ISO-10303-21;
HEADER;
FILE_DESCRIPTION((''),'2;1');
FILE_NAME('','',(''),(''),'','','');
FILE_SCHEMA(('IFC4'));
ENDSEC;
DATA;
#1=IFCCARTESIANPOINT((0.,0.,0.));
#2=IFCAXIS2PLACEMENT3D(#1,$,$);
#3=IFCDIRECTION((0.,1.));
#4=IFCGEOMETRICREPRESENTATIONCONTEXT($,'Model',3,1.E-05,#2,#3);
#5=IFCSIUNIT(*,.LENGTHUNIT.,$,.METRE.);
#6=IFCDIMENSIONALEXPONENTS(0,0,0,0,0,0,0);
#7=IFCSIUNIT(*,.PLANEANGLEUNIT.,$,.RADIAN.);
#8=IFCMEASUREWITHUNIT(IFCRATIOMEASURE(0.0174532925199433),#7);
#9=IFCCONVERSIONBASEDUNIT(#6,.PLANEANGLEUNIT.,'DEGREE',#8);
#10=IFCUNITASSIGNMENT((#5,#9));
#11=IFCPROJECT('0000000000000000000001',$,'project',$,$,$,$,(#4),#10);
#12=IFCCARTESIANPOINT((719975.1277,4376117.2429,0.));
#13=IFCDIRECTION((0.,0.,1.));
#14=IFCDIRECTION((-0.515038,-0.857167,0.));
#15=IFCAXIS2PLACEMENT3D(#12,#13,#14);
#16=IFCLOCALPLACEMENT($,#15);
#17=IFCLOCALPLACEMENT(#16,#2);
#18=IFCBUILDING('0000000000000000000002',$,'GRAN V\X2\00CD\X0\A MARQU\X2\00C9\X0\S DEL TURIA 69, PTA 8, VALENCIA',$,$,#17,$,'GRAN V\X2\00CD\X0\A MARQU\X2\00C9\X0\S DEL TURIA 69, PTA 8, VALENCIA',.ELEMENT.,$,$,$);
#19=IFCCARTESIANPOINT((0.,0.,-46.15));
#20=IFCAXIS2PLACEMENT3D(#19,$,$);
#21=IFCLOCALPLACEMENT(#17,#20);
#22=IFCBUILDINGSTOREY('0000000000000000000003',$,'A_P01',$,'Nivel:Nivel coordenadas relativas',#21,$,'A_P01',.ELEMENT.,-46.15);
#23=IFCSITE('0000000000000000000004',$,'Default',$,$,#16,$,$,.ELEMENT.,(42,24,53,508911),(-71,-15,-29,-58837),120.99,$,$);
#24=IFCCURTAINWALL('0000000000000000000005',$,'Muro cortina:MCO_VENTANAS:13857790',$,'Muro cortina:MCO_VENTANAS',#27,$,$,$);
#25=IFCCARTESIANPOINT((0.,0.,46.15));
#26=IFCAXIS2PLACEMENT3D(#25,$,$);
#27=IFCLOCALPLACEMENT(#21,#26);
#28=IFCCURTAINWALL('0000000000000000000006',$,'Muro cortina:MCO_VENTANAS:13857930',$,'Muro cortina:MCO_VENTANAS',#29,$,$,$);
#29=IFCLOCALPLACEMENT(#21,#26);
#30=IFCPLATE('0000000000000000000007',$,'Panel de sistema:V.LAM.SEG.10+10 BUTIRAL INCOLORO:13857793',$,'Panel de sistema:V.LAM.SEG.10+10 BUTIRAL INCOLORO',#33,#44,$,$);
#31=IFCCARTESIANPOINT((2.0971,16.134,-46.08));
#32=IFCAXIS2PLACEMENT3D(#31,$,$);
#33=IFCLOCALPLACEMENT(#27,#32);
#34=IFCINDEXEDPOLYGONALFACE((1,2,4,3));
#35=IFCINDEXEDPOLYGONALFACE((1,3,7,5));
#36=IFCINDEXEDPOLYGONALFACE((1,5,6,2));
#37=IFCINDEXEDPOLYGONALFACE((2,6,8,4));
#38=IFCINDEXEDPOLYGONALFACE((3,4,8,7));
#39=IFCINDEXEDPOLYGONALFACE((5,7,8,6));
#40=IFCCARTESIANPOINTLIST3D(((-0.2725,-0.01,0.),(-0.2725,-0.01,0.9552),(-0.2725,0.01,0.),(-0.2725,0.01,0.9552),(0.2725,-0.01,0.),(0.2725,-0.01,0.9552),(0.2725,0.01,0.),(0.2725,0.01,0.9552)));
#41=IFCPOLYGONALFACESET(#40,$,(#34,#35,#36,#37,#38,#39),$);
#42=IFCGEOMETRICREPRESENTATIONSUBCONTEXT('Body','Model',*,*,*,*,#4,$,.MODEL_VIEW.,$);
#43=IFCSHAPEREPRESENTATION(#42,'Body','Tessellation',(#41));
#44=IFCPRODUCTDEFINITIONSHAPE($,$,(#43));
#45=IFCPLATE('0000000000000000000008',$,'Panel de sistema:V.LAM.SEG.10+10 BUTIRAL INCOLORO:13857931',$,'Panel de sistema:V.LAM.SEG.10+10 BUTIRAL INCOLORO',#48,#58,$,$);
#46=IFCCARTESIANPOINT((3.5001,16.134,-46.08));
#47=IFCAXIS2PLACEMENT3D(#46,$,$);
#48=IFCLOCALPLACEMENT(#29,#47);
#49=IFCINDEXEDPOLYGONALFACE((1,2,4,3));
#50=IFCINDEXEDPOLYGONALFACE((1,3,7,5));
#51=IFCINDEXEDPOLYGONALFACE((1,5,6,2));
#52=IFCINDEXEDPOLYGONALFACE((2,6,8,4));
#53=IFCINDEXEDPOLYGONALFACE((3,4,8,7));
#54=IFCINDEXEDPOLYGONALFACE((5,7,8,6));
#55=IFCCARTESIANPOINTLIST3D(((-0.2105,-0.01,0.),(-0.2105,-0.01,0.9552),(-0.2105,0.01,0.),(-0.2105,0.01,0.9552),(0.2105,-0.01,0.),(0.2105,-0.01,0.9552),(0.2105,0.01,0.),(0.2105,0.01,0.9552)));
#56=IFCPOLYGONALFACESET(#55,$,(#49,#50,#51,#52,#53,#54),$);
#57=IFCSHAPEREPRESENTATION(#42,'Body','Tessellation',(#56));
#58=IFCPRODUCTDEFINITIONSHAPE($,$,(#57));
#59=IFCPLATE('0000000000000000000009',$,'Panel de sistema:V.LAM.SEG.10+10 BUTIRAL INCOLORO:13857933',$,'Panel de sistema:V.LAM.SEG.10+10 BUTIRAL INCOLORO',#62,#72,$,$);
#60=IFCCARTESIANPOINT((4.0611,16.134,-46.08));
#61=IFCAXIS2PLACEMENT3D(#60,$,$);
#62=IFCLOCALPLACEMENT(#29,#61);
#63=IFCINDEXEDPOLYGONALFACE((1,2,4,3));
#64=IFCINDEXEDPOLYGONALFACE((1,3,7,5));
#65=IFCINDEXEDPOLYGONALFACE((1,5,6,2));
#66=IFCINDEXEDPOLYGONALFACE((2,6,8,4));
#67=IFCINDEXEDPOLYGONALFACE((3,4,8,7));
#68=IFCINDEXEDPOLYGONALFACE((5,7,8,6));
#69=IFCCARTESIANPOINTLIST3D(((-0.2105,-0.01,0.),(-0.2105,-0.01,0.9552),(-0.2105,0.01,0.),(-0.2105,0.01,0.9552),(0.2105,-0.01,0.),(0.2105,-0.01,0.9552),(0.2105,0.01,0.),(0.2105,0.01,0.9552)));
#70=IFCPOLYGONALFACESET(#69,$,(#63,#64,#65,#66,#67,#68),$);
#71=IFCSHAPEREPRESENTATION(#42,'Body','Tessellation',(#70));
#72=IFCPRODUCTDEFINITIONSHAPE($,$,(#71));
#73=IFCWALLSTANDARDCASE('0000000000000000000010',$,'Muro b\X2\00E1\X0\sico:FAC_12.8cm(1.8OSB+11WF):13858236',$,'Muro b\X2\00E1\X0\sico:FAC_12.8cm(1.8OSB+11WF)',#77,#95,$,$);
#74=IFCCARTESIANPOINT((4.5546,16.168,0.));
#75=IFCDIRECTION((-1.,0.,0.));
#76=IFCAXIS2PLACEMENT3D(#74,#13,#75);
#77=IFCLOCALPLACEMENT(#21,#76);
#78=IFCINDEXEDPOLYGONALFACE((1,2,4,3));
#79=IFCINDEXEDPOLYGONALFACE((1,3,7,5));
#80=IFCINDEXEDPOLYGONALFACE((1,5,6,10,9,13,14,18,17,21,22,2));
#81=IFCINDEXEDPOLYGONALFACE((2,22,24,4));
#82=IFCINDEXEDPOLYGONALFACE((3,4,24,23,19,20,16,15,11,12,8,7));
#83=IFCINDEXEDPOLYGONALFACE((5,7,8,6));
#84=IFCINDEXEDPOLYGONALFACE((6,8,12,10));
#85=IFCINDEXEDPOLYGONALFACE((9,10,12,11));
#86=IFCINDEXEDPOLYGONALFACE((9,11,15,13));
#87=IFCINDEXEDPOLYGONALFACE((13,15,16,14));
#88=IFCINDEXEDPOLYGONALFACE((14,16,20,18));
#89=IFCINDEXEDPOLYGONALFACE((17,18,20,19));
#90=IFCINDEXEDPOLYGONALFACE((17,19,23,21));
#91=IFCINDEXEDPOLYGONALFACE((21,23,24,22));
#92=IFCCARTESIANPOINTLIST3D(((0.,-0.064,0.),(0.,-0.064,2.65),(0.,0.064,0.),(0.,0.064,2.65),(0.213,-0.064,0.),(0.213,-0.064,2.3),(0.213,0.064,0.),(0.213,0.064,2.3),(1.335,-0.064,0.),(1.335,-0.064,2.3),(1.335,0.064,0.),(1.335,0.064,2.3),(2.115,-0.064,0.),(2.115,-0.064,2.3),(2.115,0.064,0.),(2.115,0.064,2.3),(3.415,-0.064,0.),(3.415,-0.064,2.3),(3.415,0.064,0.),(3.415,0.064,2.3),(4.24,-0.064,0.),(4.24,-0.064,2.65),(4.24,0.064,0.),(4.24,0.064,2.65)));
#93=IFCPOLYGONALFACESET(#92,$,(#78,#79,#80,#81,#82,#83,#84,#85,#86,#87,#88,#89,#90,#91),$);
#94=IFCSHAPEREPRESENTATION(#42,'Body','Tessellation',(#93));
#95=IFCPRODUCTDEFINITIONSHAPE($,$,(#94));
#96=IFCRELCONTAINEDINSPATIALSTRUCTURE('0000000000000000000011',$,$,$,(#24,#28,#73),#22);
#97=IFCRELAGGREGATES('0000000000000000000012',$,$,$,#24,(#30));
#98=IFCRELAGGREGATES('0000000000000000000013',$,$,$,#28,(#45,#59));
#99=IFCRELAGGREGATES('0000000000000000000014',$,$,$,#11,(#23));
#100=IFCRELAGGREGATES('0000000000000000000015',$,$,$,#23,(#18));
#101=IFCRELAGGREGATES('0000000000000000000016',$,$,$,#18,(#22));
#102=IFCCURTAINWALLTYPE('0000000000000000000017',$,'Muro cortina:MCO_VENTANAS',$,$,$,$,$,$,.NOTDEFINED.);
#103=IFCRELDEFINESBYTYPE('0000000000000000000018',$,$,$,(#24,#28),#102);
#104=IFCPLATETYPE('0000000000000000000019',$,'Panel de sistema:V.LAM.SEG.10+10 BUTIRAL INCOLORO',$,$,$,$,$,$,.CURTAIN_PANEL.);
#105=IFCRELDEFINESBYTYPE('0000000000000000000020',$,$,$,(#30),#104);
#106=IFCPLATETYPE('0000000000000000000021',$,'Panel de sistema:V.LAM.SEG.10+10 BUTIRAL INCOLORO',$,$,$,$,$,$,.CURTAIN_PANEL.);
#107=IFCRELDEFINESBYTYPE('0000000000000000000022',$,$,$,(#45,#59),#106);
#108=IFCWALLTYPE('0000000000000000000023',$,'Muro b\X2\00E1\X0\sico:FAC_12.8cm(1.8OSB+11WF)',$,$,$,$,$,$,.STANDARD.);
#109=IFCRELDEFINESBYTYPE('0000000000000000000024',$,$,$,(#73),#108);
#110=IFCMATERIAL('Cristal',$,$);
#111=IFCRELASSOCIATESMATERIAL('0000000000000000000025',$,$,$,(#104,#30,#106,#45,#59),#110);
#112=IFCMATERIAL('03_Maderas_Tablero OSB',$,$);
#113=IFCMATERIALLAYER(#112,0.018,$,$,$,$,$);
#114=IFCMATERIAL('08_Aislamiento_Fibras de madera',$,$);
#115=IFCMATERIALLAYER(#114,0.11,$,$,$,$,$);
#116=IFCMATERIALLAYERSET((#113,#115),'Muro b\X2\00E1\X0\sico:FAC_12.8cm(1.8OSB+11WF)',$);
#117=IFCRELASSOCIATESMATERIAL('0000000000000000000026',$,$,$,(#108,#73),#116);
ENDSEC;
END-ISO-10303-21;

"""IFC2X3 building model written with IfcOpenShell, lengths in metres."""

from ifc_helpers import new_model, entity, si_unit, converted_unit, direction, frame, frame_2d, origin, origin_2d_with_axis, place, context, subcontext, project, spatial, rectangle, extrude, source, transform, mapped, material, layer, layer_set, layer_usage, type_object, type_shapes, element, aggregate, save


model = new_model("IFC2X3")

# Units and contexts
model_context = context("Model", 3, precision=1e-05, world=origin(), true_north=direction((0.0, 1.0)))
body_context = subcontext(model_context, "Body", "Model", "MODEL_VIEW")
ifc_project = project(units=[si_unit("LENGTHUNIT", "METRE"), converted_unit("PLANEANGLEUNIT", "DEGREE", entity("IfcRatioMeasure", 0.0174532925199433), si_unit("PLANEANGLEUNIT", "RADIAN"), dimensions=[0, 0, 0, 0, 0, 0, 0])], contexts=[model_context])

# Site, building, storey
site_placement = place(None, frame((719975.1277, 4376117.2429, 0.0), z_axis=(0.0, 0.0, 1.0), x_axis=(-0.515038, -0.857167, 0.0)))
site = spatial("IfcSite", under=ifc_project, at=site_placement, Name="Default", CompositionType="ELEMENT", RefLatitude=(42, 24, 53, 508911), RefLongitude=(-71, -15, -29, -58837), RefElevation=120.99)
building_placement = place(site_placement, origin())
building = spatial("IfcBuilding", under=site, at=building_placement, Name="GRAN VÍA MARQUÉS DEL TURIA 69, PTA 8, VALENCIA", LongName="GRAN VÍA MARQUÉS DEL TURIA 69, PTA 8, VALENCIA", CompositionType="ELEMENT")
storey_placement = place(building_placement, frame((0.0, 0.0, -46.15)))
storey = spatial("IfcBuildingStorey", under=building, at=storey_placement, Name="A_P01", ObjectType="Nivel:Nivel coordenadas relativas", LongName="A_P01", CompositionType="ELEMENT", Elevation=-46.15)

# Curtain wall
curtain_wall_type = type_object("IfcCurtainWallType", Name="Muro cortina:MCO_VENTANAS", PredefinedType="NOTDEFINED")
curtain_wall_1_placement = place(storey_placement, frame((0.0, 0.0, 46.15)))
curtain_wall_1 = element("IfcCurtainWall", 1, at=curtain_wall_1_placement, inside=storey, type_object=curtain_wall_type, Name="Muro cortina:MCO_VENTANAS:13857790", ObjectType="Muro cortina:MCO_VENTANAS")

# Curtain wall
curtain_wall_2_placement = place(storey_placement, frame((0.0, 0.0, 46.15)))
curtain_wall_2 = element("IfcCurtainWall", 2, at=curtain_wall_2_placement, inside=storey, type_object=curtain_wall_type, Name="Muro cortina:MCO_VENTANAS:13857930", ObjectType="Muro cortina:MCO_VENTANAS")

# Plates
ifc_material_1 = material(Name="Cristal")
plate_type_1 = type_object("IfcPlateType", Name="Panel de sistema:V.LAM.SEG.10+10 BUTIRAL INCOLORO", PredefinedType="CURTAIN_PANEL", material=ifc_material_1)
shared_shape_1 = source(origin(), body_context, "Body", "SweptSolid", [
    extrude(rectangle(XDim=0.02, YDim=0.545, at=origin_2d_with_axis()), frame((0.0, 0.0, 0.0), z_axis=(0.0, 0.0, 1.0), x_axis=(0.0, 1.0, 0.0)), (0.0, 0.0, 1.0), 0.9552),
])
type_shapes(plate_type_1, [shared_shape_1])
plate_1_placement = place(curtain_wall_1_placement, frame((2.0971, 16.134, -46.08)))
plate_1 = element("IfcPlate", 3, at=plate_1_placement, type_object=plate_type_1, material=ifc_material_1, Name="Panel de sistema:V.LAM.SEG.10+10 BUTIRAL INCOLORO:13857793", ObjectType="Panel de sistema:V.LAM.SEG.10+10 BUTIRAL INCOLORO", context=body_context, shape_type="MappedRepresentation", body=[
    mapped(shared_shape_1, transform((0.0, 0.0, 0.0), scale=1.0)),
])
aggregate(curtain_wall_1, [plate_1])
plate_type_2 = type_object("IfcPlateType", Name="Panel de sistema:V.LAM.SEG.10+10 BUTIRAL INCOLORO", PredefinedType="CURTAIN_PANEL", material=ifc_material_1)
shared_shape_2 = source(origin(), body_context, "Body", "SweptSolid", [
    extrude(rectangle(XDim=0.02, YDim=0.421, at=origin_2d_with_axis()), frame((0.0, 0.0, 0.0), z_axis=(0.0, 0.0, 1.0), x_axis=(0.0, 1.0, 0.0)), (0.0, 0.0, 1.0), 0.9552),
])
type_shapes(plate_type_2, [shared_shape_2])
plate_2_placement = place(curtain_wall_2_placement, frame((3.5001, 16.134, -46.08)))
plate_2 = element("IfcPlate", 4, at=plate_2_placement, type_object=plate_type_2, material=ifc_material_1, Name="Panel de sistema:V.LAM.SEG.10+10 BUTIRAL INCOLORO:13857931", ObjectType="Panel de sistema:V.LAM.SEG.10+10 BUTIRAL INCOLORO", context=body_context, shape_type="MappedRepresentation", body=[
    mapped(shared_shape_2, transform((0.0, 0.0, 0.0), scale=1.0)),
])
plate_3_placement = place(curtain_wall_2_placement, frame((4.0611, 16.134, -46.08)))
plate_3 = element("IfcPlate", 5, at=plate_3_placement, type_object=plate_type_2, material=ifc_material_1, Name="Panel de sistema:V.LAM.SEG.10+10 BUTIRAL INCOLORO:13857933", ObjectType="Panel de sistema:V.LAM.SEG.10+10 BUTIRAL INCOLORO", context=body_context, shape_type="MappedRepresentation", body=[
    mapped(shared_shape_2, transform((0.0, 0.0, 0.0), scale=1.0)),
])
aggregate(curtain_wall_2, [plate_2, plate_3])

# Wall, openings
ifc_material_2 = material(Name="03_Maderas_Tablero OSB")
ifc_layer_1 = layer(ifc_material_2, 0.018)
ifc_material_3 = material(Name="08_Aislamiento_Fibras de madera")
ifc_layer_2 = layer(ifc_material_3, 0.11)
ifc_layer_set_1 = layer_set([ifc_layer_1, ifc_layer_2], Name="Muro básico:FAC_12.8cm(1.8OSB+11WF)")
ifc_layer_usage_1 = layer_usage(ifc_layer_set_1, "AXIS2", "NEGATIVE", 0.064)
wall_type_1 = type_object("IfcWallType", Name="Muro básico:FAC_12.8cm(1.8OSB+11WF)", PredefinedType="STANDARD", material=ifc_layer_set_1)
wall_1_placement = place(storey_placement, frame((4.5546, 16.168, 0.0), z_axis=(0.0, 0.0, 1.0), x_axis=(-1.0, 0.0, 0.0)))
wall_1 = element("IfcWallStandardCase", 6, at=wall_1_placement, inside=storey, type_object=wall_type_1, material=ifc_layer_usage_1, Name="Muro básico:FAC_12.8cm(1.8OSB+11WF):13858236", ObjectType="Muro básico:FAC_12.8cm(1.8OSB+11WF)", context=body_context, shape_type="SweptSolid", body=[
    extrude(rectangle(XDim=4.24, YDim=0.128, at=frame_2d((2.12, 0.0), x_axis=(-1.0, 0.0))), origin(), (0.0, 0.0, 1.0), 2.65),
])
opening_1_placement = place(wall_1_placement, origin())
element("IfcOpeningElement", 7, at=opening_1_placement, cuts=wall_1, ObjectType="Opening", context=body_context, shape_type="SweptSolid", body=[
    extrude(rectangle(XDim=2.3, YDim=1.122, at=frame_2d((0.0, 0.0), x_axis=(0.0, 1.0))), frame((0.774, -0.2164, 1.15), z_axis=(0.0, 1.0, 0.0), x_axis=(-1.0, 0.0, 0.0)), (0.0, 0.0, 1.0), 0.4328),
])
opening_2_placement = place(wall_1_placement, origin())
element("IfcOpeningElement", 8, at=opening_2_placement, cuts=wall_1, ObjectType="Opening", context=body_context, shape_type="SweptSolid", body=[
    extrude(rectangle(XDim=2.3, YDim=1.3, at=frame_2d((0.0, 0.0), x_axis=(0.0, 1.0))), frame((2.765, -0.2164, 1.15), z_axis=(0.0, 1.0, 0.0), x_axis=(-1.0, 0.0, 0.0)), (0.0, 0.0, 1.0), 0.4328),
])

save(model, "model.ifc")
